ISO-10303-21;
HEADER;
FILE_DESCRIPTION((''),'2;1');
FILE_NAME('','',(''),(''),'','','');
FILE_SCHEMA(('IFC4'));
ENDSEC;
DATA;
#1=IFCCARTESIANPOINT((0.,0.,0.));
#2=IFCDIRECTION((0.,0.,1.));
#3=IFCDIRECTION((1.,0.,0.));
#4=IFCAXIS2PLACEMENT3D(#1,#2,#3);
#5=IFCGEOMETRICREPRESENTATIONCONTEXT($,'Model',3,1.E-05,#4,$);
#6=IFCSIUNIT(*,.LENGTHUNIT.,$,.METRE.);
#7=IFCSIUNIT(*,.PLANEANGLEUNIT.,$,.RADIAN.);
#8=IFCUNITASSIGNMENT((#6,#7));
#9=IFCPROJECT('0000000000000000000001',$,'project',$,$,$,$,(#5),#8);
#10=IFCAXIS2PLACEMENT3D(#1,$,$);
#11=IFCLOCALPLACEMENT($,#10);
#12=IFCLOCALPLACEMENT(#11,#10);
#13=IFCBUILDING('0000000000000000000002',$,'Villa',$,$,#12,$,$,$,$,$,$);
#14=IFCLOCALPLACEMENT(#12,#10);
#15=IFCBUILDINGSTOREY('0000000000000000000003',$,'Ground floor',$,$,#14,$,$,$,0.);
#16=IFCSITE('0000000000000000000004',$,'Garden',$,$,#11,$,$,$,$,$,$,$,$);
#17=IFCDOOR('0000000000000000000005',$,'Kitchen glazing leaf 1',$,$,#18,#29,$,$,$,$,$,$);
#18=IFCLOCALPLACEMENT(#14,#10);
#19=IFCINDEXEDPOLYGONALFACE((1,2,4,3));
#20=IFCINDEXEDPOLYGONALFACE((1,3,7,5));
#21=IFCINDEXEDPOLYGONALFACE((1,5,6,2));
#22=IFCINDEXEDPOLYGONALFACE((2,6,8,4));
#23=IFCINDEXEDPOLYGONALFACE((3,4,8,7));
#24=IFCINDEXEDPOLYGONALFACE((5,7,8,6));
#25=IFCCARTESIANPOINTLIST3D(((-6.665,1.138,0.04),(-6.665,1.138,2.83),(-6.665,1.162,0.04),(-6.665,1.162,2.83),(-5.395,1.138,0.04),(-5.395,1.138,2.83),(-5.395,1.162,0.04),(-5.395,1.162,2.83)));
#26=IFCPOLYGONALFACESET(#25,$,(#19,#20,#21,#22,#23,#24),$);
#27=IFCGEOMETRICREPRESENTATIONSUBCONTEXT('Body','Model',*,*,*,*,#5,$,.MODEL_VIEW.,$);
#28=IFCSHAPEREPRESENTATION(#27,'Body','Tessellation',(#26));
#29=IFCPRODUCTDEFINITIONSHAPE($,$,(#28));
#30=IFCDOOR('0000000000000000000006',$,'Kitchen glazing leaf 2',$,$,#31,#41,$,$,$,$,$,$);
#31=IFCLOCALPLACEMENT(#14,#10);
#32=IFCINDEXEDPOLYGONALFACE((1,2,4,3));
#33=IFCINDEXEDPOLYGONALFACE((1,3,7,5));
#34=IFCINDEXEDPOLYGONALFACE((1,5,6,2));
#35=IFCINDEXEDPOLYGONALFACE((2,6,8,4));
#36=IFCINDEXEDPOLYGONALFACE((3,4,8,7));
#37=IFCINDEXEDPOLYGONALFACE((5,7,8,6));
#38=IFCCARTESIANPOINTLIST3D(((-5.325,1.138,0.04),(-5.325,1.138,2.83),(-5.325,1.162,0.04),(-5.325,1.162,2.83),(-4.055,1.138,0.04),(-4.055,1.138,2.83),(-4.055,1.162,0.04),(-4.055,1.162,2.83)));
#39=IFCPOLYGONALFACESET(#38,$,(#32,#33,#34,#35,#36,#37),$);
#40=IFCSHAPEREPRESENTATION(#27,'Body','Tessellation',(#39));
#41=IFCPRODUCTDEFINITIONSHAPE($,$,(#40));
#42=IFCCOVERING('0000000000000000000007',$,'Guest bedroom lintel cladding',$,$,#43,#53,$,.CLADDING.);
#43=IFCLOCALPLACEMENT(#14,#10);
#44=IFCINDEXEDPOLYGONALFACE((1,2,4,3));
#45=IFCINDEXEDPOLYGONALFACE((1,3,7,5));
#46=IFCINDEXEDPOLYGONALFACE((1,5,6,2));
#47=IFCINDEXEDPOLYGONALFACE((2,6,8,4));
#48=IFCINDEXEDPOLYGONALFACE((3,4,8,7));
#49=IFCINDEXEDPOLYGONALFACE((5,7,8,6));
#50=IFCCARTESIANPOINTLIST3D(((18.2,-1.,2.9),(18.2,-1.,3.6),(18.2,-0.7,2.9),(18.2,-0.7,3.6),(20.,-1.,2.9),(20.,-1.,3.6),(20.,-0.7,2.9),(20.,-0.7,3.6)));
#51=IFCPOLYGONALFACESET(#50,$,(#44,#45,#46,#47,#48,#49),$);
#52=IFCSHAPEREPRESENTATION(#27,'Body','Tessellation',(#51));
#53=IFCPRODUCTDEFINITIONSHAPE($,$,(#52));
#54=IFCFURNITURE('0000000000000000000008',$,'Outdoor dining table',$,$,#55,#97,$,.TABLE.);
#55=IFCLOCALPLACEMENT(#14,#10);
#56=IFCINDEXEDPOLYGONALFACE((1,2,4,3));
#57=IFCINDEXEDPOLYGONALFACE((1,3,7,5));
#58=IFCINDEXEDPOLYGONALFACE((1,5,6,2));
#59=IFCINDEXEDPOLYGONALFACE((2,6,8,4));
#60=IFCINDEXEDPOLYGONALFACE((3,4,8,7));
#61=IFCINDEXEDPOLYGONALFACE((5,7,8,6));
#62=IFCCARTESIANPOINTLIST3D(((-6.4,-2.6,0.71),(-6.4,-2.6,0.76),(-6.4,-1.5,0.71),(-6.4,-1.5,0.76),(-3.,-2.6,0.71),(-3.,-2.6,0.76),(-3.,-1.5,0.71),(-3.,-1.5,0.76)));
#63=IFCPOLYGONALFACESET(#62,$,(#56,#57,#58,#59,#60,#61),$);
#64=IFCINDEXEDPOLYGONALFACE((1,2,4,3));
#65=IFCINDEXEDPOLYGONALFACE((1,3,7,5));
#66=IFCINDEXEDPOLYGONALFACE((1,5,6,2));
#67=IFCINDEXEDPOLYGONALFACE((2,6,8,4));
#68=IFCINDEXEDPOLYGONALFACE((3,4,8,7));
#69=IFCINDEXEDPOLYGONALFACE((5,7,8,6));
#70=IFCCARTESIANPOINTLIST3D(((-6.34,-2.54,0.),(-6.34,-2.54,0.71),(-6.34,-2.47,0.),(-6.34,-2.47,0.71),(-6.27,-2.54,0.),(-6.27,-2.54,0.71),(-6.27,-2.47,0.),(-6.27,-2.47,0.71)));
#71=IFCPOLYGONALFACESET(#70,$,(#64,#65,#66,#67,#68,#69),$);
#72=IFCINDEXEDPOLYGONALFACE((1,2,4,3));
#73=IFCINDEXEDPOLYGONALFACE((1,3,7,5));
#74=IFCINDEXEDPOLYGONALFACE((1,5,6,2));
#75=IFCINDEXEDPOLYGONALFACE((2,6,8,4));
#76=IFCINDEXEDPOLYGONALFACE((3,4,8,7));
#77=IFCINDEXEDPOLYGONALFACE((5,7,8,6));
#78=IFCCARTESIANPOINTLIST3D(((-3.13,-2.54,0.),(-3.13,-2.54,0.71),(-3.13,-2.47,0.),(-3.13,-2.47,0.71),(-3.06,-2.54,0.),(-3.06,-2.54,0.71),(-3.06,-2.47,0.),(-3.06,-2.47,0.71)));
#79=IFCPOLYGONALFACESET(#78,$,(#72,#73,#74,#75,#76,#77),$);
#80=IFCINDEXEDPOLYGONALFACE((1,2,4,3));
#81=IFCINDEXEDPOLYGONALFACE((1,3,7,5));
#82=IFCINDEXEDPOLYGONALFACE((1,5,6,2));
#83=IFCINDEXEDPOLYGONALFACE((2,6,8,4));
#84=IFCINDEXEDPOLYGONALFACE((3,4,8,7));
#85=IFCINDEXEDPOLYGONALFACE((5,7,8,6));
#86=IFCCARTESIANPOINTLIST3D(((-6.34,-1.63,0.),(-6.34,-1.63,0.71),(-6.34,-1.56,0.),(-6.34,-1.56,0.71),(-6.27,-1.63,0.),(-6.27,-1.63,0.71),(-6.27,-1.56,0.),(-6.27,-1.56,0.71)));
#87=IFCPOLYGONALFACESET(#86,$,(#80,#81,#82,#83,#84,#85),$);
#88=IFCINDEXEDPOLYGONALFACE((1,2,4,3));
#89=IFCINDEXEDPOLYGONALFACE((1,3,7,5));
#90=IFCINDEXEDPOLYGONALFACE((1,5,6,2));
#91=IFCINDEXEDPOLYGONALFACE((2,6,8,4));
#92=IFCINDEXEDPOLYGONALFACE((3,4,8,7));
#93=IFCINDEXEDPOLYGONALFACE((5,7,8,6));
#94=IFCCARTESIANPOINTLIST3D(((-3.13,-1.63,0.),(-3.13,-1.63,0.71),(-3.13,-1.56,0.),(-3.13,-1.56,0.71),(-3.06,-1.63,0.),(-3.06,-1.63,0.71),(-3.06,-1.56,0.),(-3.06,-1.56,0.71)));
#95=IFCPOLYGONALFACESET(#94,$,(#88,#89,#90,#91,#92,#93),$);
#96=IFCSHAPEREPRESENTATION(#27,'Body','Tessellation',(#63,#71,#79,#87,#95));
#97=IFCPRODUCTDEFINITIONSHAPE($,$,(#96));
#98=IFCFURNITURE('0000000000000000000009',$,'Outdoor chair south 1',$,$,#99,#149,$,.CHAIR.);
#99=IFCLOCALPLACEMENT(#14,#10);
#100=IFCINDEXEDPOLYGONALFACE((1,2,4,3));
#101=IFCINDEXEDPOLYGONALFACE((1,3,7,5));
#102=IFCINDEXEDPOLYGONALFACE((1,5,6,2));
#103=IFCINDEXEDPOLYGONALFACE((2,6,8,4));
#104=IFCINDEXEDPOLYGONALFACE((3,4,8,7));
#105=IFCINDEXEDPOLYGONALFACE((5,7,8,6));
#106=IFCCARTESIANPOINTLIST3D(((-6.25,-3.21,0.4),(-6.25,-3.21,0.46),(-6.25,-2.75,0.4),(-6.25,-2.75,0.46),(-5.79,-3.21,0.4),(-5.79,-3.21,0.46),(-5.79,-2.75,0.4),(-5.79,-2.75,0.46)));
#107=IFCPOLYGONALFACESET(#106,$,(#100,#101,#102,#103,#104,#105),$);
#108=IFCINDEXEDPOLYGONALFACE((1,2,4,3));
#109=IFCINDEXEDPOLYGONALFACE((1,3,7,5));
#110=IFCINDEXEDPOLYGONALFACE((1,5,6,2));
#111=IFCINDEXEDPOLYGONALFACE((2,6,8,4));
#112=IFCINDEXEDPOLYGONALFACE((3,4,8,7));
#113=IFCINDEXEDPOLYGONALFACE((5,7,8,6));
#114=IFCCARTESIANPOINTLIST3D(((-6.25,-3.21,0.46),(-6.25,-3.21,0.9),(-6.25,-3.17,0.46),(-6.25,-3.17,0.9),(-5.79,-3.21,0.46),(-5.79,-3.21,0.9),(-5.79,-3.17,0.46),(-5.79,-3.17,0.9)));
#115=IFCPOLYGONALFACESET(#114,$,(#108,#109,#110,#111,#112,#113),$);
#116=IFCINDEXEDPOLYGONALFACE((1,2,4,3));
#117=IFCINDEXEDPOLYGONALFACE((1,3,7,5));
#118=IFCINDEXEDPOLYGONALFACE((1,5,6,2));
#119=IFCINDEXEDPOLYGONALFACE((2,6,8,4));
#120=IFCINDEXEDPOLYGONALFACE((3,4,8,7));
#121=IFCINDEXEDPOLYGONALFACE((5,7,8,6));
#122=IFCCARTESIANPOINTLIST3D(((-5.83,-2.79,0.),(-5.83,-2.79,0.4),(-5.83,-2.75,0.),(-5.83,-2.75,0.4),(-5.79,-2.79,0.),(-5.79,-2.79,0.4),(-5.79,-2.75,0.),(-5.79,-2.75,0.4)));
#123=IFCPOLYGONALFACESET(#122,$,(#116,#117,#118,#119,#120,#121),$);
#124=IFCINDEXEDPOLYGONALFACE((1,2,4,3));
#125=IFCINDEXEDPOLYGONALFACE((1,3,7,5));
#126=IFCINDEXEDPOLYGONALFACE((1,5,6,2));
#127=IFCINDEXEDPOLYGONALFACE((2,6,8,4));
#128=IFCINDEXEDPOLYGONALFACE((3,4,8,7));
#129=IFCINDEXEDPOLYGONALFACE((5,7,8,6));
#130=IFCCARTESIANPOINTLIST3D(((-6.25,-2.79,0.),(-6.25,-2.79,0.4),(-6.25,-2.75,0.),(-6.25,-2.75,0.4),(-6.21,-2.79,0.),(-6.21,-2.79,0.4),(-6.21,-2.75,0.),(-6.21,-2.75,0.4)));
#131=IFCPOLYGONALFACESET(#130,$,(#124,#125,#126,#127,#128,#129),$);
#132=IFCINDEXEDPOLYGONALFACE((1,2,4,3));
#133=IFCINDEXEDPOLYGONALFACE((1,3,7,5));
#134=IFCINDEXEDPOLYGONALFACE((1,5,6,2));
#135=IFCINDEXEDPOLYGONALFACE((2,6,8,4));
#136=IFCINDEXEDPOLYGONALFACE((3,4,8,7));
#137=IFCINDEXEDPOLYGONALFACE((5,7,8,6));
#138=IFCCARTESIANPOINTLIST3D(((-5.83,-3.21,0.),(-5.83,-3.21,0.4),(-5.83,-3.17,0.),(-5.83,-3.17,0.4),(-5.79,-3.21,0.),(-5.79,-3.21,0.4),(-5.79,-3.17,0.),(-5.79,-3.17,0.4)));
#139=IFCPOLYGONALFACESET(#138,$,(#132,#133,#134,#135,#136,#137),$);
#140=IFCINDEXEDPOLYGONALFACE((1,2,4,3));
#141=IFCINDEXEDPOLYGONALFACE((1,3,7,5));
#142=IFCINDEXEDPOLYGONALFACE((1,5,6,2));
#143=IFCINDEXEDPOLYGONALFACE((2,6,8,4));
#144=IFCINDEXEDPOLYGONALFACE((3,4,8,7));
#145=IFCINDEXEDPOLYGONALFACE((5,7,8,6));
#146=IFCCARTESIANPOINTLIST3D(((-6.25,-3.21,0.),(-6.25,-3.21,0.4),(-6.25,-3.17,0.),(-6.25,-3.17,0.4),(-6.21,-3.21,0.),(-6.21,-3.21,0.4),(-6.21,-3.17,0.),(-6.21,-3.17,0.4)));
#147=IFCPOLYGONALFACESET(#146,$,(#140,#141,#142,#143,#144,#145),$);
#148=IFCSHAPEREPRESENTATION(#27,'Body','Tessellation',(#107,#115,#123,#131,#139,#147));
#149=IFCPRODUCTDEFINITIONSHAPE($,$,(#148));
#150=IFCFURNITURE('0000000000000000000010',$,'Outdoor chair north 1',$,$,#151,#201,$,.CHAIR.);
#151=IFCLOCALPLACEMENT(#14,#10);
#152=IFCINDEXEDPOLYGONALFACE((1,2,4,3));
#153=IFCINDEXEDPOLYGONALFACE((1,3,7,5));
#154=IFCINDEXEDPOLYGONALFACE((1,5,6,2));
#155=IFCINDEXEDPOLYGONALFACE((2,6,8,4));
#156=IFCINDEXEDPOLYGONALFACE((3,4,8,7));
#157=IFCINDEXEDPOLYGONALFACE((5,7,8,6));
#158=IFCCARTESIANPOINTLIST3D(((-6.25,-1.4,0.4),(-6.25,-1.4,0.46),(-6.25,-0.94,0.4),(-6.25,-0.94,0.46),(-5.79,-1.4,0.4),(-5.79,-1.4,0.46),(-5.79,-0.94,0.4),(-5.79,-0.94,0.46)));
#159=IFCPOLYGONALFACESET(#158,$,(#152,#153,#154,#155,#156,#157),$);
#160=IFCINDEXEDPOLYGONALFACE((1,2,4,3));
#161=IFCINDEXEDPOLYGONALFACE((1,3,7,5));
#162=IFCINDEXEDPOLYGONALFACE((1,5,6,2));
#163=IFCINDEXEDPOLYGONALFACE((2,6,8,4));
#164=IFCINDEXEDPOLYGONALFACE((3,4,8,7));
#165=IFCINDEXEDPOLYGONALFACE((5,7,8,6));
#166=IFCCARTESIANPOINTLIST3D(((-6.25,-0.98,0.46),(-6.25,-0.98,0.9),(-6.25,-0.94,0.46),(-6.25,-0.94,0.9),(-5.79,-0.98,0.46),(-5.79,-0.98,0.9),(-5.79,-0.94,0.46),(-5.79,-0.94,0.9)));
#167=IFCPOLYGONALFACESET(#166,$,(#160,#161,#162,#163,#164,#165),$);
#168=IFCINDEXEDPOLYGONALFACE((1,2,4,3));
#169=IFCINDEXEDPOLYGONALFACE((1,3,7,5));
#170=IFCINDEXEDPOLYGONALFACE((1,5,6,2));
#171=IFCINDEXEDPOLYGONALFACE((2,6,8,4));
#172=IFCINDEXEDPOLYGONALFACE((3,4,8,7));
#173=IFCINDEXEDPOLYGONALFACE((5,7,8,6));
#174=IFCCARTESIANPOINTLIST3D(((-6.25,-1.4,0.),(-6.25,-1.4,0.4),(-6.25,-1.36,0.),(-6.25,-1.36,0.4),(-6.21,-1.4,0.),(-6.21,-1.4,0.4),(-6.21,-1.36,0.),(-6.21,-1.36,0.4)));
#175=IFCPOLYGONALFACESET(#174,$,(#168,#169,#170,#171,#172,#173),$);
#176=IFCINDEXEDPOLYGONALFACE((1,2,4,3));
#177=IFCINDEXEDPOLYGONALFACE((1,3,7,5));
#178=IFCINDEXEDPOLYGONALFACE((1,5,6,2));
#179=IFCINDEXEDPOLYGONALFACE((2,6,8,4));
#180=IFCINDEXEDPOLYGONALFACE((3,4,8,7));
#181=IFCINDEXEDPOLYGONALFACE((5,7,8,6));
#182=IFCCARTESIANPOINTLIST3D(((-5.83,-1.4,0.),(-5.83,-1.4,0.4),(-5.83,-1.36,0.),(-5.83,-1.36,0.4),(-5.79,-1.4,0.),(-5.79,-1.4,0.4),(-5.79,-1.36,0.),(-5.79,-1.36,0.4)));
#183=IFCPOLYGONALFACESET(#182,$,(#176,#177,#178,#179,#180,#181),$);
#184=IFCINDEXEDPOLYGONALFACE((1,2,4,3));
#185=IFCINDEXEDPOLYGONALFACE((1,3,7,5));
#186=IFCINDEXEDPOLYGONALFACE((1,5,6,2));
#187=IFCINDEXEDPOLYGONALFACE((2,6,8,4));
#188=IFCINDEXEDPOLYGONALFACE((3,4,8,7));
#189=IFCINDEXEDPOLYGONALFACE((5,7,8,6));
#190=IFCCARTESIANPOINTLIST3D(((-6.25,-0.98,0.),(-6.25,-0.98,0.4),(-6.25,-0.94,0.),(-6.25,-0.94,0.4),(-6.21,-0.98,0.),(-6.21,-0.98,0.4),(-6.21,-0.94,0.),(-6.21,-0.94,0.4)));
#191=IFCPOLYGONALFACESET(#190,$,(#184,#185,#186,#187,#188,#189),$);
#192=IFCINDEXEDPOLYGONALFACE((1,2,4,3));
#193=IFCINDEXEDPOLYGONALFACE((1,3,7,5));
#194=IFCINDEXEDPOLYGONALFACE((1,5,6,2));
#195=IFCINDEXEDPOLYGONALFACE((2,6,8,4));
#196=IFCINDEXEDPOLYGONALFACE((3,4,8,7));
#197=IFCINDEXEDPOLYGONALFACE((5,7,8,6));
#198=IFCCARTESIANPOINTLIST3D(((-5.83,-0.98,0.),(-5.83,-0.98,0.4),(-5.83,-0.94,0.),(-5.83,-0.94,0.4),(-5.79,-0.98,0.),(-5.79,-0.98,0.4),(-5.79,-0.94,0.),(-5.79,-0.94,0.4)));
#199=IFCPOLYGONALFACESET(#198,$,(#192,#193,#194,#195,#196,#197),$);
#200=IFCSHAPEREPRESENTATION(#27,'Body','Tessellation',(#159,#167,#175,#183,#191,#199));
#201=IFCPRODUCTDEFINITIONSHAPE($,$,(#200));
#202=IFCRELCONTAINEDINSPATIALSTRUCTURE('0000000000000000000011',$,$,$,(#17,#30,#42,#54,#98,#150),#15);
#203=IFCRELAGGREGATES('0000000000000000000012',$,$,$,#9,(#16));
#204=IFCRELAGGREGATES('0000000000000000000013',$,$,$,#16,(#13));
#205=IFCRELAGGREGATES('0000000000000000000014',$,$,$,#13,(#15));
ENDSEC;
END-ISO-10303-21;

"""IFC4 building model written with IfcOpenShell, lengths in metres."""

from ifc_helpers import new_model, si_unit, frame, frame_2d, origin, origin_with_axes, place, context, subcontext, project, spatial, rectangle, extrude, element, save


model = new_model("IFC4")

# Units and contexts
model_context = context("Model", 3, precision=1e-05, world=origin_with_axes())
body_context = subcontext(model_context, "Body", "Model", "MODEL_VIEW")
ifc_project = project(units=[si_unit("LENGTHUNIT", "METRE"), si_unit("PLANEANGLEUNIT", "RADIAN")], contexts=[model_context])

# Site, building, storey
site_placement = place(None, origin())
site = spatial("IfcSite", under=ifc_project, at=site_placement, Name="Garden")
building_placement = place(site_placement, origin())
building = spatial("IfcBuilding", under=site, at=building_placement, Name="Villa")
storey_placement = place(building_placement, origin())
storey = spatial("IfcBuildingStorey", under=building, at=storey_placement, Name="Ground floor", Elevation=0.0)

# Doors
door_1_placement = place(storey_placement, origin())
element("IfcDoor", 1, at=door_1_placement, inside=storey, Name="Kitchen glazing leaf 1", context=body_context, shape_type="SweptSolid", body=[
    extrude(rectangle(XDim=1.27, YDim=0.024, at=frame_2d((0.635, 0.012))), frame((-6.665, 1.138, 0.04)), (0.0, 0.0, 1.0), 2.79),
])
door_2_placement = place(storey_placement, origin())
element("IfcDoor", 2, at=door_2_placement, inside=storey, Name="Kitchen glazing leaf 2", context=body_context, shape_type="SweptSolid", body=[
    extrude(rectangle(XDim=1.27, YDim=0.024, at=frame_2d((0.635, 0.012))), frame((-5.325, 1.138, 0.04)), (0.0, 0.0, 1.0), 2.79),
])

# Covering
covering_placement = place(storey_placement, origin())
element("IfcCovering", 3, at=covering_placement, inside=storey, Name="Guest bedroom lintel cladding", PredefinedType="CLADDING", context=body_context, shape_type="SweptSolid", body=[
    extrude(rectangle(XDim=1.8, YDim=0.3, at=frame_2d((0.9, 0.15))), frame((18.2, -1.0, 2.9)), (0.0, 0.0, 1.0), 0.7),
])

# Furniture
furniture_1_placement = place(storey_placement, frame((-6.4, -2.6, 0.0)))
element("IfcFurniture", 4, at=furniture_1_placement, inside=storey, Name="Outdoor dining table", PredefinedType="TABLE", context=body_context, shape_type="SweptSolid", body=[
    extrude(rectangle(XDim=3.4, YDim=1.1, at=frame_2d((1.7, 0.55))), frame((0.0, 0.0, 0.71)), (0.0, 0.0, 1.0), 0.05),
    extrude(rectangle(XDim=0.07, YDim=0.07, at=frame_2d((0.035, 0.035))), frame((0.06, 0.06, 0.0)), (0.0, 0.0, 1.0), 0.71),
    extrude(rectangle(XDim=0.07, YDim=0.07, at=frame_2d((0.035, 0.035))), frame((3.27, 0.06, 0.0)), (0.0, 0.0, 1.0), 0.71),
    extrude(rectangle(XDim=0.07, YDim=0.07, at=frame_2d((0.035, 0.035))), frame((0.06, 0.97, 0.0)), (0.0, 0.0, 1.0), 0.71),
    extrude(rectangle(XDim=0.07, YDim=0.07, at=frame_2d((0.035, 0.035))), frame((3.27, 0.97, 0.0)), (0.0, 0.0, 1.0), 0.71),
])
furniture_2_placement = place(storey_placement, frame((-5.79, -2.75, 0.0), x_axis=(-1.0, 0.0, 0.0)))
element("IfcFurniture", 5, at=furniture_2_placement, inside=storey, Name="Outdoor chair south 1", PredefinedType="CHAIR", context=body_context, shape_type="SweptSolid", body=[
    extrude(rectangle(XDim=0.46, YDim=0.46, at=frame_2d((0.23, 0.23))), frame((0.0, 0.0, 0.4)), (0.0, 0.0, 1.0), 0.06),
    extrude(rectangle(XDim=0.46, YDim=0.04, at=frame_2d((0.23, 0.02))), frame((0.0, 0.42, 0.46)), (0.0, 0.0, 1.0), 0.44),
    extrude(rectangle(XDim=0.04, YDim=0.04, at=frame_2d((0.02, 0.02))), origin(), (0.0, 0.0, 1.0), 0.4),
    extrude(rectangle(XDim=0.04, YDim=0.04, at=frame_2d((0.02, 0.02))), frame((0.42, 0.0, 0.0)), (0.0, 0.0, 1.0), 0.4),
    extrude(rectangle(XDim=0.04, YDim=0.04, at=frame_2d((0.02, 0.02))), frame((0.0, 0.42, 0.0)), (0.0, 0.0, 1.0), 0.4),
    extrude(rectangle(XDim=0.04, YDim=0.04, at=frame_2d((0.02, 0.02))), frame((0.42, 0.42, 0.0)), (0.0, 0.0, 1.0), 0.4),
])
furniture_3_placement = place(storey_placement, frame((-6.25, -1.4, 0.0)))
element("IfcFurniture", 6, at=furniture_3_placement, inside=storey, Name="Outdoor chair north 1", PredefinedType="CHAIR", context=body_context, shape_type="SweptSolid", body=[
    extrude(rectangle(XDim=0.46, YDim=0.46, at=frame_2d((0.23, 0.23))), frame((0.0, 0.0, 0.4)), (0.0, 0.0, 1.0), 0.06),
    extrude(rectangle(XDim=0.46, YDim=0.04, at=frame_2d((0.23, 0.02))), frame((0.0, 0.42, 0.46)), (0.0, 0.0, 1.0), 0.44),
    extrude(rectangle(XDim=0.04, YDim=0.04, at=frame_2d((0.02, 0.02))), origin(), (0.0, 0.0, 1.0), 0.4),
    extrude(rectangle(XDim=0.04, YDim=0.04, at=frame_2d((0.02, 0.02))), frame((0.42, 0.0, 0.0)), (0.0, 0.0, 1.0), 0.4),
    extrude(rectangle(XDim=0.04, YDim=0.04, at=frame_2d((0.02, 0.02))), frame((0.0, 0.42, 0.0)), (0.0, 0.0, 1.0), 0.4),
    extrude(rectangle(XDim=0.04, YDim=0.04, at=frame_2d((0.02, 0.02))), frame((0.42, 0.42, 0.0)), (0.0, 0.0, 1.0), 0.4),
])

save(model, "model.ifc")
